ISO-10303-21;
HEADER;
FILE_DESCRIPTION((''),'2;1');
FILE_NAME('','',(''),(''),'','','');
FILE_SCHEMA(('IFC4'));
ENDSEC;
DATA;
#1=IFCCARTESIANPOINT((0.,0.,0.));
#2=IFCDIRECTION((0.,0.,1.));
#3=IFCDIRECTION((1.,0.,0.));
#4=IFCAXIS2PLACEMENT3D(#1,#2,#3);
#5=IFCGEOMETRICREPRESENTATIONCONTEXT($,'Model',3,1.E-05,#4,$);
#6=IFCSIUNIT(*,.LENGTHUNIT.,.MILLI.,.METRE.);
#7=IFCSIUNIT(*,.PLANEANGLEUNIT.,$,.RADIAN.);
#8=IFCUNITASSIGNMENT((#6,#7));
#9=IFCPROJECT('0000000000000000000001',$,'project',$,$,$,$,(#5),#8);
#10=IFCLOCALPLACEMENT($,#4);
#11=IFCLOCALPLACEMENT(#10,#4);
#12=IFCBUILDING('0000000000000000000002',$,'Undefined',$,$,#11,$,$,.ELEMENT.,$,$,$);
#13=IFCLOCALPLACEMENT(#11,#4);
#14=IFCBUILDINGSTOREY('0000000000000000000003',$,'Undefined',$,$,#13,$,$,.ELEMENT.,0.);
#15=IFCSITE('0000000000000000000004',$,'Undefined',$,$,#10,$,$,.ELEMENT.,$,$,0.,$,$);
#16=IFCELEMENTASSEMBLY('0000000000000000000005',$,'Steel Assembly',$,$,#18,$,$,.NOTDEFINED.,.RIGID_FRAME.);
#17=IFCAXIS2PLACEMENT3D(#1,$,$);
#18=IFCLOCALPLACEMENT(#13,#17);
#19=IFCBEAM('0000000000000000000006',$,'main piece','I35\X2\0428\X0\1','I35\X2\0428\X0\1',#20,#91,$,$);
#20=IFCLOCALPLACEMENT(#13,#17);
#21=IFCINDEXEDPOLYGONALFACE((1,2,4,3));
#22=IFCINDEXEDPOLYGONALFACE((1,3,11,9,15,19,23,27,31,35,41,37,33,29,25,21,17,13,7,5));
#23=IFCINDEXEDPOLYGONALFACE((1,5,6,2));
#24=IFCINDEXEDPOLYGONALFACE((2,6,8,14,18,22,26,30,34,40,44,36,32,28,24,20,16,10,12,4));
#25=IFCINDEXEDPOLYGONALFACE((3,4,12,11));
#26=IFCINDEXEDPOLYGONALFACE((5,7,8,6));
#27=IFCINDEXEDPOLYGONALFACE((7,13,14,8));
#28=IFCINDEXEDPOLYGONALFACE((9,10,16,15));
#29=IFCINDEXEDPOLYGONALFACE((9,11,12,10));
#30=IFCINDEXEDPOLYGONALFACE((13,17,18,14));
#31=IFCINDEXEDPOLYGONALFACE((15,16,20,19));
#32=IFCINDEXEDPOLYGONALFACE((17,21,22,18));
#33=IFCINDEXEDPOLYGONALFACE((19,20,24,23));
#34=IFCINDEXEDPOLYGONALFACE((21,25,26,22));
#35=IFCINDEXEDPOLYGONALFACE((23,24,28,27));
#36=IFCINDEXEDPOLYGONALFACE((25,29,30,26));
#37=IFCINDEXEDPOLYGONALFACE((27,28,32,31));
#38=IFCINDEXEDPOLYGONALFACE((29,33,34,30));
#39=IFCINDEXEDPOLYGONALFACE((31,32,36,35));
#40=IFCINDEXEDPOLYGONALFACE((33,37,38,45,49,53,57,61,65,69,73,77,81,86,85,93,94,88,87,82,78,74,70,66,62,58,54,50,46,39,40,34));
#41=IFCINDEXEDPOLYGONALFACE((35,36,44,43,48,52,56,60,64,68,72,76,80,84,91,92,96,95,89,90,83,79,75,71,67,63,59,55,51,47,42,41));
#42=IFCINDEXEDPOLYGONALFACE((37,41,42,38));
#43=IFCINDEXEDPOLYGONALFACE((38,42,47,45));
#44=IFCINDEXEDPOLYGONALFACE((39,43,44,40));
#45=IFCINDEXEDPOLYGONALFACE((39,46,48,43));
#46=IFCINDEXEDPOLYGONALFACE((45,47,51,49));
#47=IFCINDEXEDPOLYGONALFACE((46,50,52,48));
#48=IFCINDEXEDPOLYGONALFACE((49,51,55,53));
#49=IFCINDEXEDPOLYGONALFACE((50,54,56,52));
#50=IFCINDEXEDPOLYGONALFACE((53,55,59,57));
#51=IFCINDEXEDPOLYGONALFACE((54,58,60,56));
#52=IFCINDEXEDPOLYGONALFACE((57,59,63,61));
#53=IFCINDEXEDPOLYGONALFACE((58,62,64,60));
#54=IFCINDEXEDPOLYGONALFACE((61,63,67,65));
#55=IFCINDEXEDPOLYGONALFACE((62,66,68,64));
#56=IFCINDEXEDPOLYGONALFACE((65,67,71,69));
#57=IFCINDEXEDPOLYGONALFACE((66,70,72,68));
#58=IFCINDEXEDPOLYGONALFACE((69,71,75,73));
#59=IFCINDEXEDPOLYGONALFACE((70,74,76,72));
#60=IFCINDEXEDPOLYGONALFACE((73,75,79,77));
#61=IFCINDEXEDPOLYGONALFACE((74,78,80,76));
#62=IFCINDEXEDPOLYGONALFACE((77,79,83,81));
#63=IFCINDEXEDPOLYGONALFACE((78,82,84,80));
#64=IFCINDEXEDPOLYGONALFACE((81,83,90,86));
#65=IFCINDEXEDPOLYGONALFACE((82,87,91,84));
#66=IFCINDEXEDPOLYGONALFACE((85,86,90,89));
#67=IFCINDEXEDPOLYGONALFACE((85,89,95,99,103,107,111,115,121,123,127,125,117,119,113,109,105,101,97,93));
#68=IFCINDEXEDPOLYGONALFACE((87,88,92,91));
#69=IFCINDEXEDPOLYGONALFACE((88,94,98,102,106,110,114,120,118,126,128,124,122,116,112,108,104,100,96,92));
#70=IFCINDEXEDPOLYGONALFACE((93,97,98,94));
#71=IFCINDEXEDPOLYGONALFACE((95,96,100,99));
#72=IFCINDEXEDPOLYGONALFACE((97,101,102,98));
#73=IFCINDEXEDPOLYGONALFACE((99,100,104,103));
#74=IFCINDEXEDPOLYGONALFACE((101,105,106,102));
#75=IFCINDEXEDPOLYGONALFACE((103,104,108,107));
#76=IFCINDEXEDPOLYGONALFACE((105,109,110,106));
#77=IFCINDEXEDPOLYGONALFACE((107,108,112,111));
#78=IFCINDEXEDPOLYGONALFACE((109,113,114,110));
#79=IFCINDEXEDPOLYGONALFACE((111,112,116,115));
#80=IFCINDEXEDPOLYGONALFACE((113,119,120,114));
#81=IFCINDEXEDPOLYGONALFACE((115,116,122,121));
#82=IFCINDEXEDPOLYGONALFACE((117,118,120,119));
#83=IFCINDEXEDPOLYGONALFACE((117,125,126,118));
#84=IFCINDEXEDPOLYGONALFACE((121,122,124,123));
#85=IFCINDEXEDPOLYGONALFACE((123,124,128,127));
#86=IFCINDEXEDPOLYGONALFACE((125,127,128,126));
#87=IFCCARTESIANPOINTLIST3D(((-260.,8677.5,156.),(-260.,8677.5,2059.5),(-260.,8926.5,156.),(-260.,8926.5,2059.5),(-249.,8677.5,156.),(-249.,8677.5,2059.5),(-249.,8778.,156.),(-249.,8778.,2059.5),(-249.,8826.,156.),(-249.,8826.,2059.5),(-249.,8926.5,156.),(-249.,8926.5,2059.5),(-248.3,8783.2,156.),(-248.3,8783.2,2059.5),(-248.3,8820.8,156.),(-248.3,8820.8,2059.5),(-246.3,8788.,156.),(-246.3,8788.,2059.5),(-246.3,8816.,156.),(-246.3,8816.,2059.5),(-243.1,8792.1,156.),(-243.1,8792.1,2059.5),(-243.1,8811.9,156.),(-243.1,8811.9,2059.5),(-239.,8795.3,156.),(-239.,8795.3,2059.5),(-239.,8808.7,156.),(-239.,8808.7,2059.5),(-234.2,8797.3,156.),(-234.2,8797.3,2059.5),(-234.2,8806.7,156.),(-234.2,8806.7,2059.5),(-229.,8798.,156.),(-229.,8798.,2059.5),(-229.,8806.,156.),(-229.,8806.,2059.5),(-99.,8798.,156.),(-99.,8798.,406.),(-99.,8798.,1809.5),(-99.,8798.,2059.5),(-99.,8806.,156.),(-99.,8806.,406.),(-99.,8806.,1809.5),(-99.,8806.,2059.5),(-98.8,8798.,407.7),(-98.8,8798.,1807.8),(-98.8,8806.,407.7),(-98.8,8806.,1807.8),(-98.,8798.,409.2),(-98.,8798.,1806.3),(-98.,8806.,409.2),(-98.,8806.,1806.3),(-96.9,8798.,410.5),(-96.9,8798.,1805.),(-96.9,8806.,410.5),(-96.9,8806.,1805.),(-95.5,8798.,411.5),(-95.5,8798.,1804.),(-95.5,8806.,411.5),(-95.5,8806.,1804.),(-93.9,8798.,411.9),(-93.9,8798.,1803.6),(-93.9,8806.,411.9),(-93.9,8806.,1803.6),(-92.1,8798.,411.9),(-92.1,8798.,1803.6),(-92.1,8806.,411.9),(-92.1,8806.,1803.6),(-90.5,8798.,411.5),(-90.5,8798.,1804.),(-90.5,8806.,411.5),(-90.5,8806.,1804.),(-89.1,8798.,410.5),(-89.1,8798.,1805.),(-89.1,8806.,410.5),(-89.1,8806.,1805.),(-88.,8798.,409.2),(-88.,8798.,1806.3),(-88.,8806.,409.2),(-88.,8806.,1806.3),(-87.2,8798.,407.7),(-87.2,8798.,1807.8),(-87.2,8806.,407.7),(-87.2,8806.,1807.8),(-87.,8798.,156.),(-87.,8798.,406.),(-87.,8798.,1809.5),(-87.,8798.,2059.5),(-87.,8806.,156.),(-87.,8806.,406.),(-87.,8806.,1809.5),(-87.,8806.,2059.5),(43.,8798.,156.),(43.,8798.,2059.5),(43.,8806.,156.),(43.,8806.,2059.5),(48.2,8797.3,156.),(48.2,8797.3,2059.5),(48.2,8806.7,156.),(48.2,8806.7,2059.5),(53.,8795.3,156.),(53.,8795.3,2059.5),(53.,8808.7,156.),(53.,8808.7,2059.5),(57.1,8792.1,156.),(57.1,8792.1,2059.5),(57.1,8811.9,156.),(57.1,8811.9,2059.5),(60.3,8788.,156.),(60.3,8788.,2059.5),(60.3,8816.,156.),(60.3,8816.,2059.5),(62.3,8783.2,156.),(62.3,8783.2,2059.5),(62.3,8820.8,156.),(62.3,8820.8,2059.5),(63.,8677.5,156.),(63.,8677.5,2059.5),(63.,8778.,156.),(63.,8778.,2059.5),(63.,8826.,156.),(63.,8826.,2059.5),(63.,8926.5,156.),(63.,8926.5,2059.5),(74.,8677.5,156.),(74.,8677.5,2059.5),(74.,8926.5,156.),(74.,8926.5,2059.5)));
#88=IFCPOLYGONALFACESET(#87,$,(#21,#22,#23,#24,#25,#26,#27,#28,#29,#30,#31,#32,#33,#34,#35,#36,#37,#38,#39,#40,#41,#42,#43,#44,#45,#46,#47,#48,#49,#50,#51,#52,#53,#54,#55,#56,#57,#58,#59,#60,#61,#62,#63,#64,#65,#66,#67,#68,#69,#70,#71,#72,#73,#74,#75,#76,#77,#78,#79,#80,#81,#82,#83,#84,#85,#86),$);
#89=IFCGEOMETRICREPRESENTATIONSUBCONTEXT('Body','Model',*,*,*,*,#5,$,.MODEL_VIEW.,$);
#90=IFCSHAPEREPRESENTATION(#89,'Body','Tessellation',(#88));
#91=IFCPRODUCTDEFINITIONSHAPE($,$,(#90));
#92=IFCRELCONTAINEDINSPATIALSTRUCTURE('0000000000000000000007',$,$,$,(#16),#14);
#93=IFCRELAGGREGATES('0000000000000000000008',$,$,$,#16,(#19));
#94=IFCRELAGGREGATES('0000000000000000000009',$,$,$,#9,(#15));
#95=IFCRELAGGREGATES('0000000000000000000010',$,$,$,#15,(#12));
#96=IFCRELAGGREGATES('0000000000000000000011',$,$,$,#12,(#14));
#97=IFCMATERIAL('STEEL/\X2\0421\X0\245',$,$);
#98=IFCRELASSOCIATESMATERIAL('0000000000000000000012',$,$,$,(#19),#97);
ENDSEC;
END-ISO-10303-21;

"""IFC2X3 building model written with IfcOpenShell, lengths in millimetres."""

from ifc_helpers import new_model, si_unit, frame, frame_2d, origin_with_axes, origin_2d_with_axis, place, context, subcontext, project, spatial, polyline, circle_curve, parameter, trimmed, segment, composite_curve, i_section, outline, extrude, clip, halfspace, material, element, aggregate, save


model = new_model("IFC2X3")

# Units and contexts
model_context = context("Model", 3, precision=1e-05, world=origin_with_axes())
body_context = subcontext(model_context, "Body", "Model", "MODEL_VIEW")
ifc_project = project(units=[si_unit("LENGTHUNIT", "METRE", prefix="MILLI"), si_unit("PLANEANGLEUNIT", "RADIAN")], contexts=[model_context])

# Site, building, storey
site_placement = place(None, origin_with_axes())
site = spatial("IfcSite", under=ifc_project, at=site_placement, Name="Undefined", CompositionType="ELEMENT", RefElevation=0.0)
building_placement = place(site_placement, origin_with_axes())
building = spatial("IfcBuilding", under=site, at=building_placement, Name="Undefined", CompositionType="ELEMENT")
storey_placement = place(building_placement, origin_with_axes())
storey = spatial("IfcBuildingStorey", under=building, at=storey_placement, Name="Undefined", CompositionType="ELEMENT", Elevation=0.0)

# Element assembly, beam, openings
assembly_1_placement = place(storey_placement, origin_with_axes())
assembly_1 = element("IfcElementAssembly", 1, at=assembly_1_placement, inside=storey, Name="Steel Assembly", AssemblyPlace="NOTDEFINED", PredefinedType="RIGID_FRAME")
ifc_material_1 = material(Name="STEEL/С245")
beam_placement = place(assembly_1_placement, frame((-93.0, 8802.0, 2059.5), z_axis=(-1.0, 0.0, 0.0), x_axis=(0.0, 0.0, -1.0)))
beam = element("IfcBeam", 2, at=beam_placement, material=ifc_material_1, Name="main piece", Description="I35Ш1", ObjectType="I35Ш1", context=body_context, shape_type="Clipping", body=[
    clip(clip(extrude(i_section(OverallWidth=249.0, OverallDepth=334.0, WebThickness=8.0, FlangeThickness=11.0, FilletRadius=20.0, at=origin_2d_with_axis()), frame((1903.5, 0.0, 0.0), z_axis=(-1.0, 0.0, 0.0), x_axis=(0.0, -1.0, 0.0)), (0.0, 0.0, 1.0), 1903.5), halfspace(frame((1903.5, 0.6, 274.0), z_axis=(-1.0, 0.0, 0.0), x_axis=(0.0, -1.0, 0.0)), True)), halfspace(frame((0.0, -0.6, 274.0), z_axis=(1.0, 0.0, 0.0), x_axis=(0.0, 1.0, 0.0)), True)),
])
opening_1_placement = place(assembly_1_placement, frame((-93.0, 8802.0, 2059.5), z_axis=(-1.0, 0.0, 0.0), x_axis=(0.0, 0.0, -1.0)))
element("IfcOpeningElement", 3, at=opening_1_placement, cuts=beam, ObjectType="Recess", context=body_context, shape_type="SweptSolid", body=[
    extrude(outline(composite_curve([segment(polyline([(0.0, 0.0), (250.0, 0.0)]), True, "CONTINUOUS"), segment(trimmed(circle_curve(frame_2d((250.0, 6.0), x_axis=(-0.000939, -1.0)), 6.0), [parameter(0.0)], [parameter(3.14347)], True, "PARAMETER"), True, "CONTINUOUS"), segment(polyline([(250.0, 12.0), (0.0, 12.0), (0.0, 0.0)]), True, "DISCONTINUOUS")], self_intersect=False)), frame((0.0, 102.5, -6.0), z_axis=(0.0, -1.0, 0.0), x_axis=(1.0, 0.0, 0.0)), (0.0, 0.0, 1.0), 205.0),
])
opening_2_placement = place(assembly_1_placement, frame((-93.0, 8802.0, 2059.5), z_axis=(-1.0, 0.0, 0.0), x_axis=(0.0, 0.0, -1.0)))
element("IfcOpeningElement", 4, at=opening_2_placement, cuts=beam, ObjectType="Recess", context=body_context, shape_type="SweptSolid", body=[
    extrude(outline(composite_curve([segment(polyline([(0.0, 0.0), (250.0, 0.0)]), True, "CONTINUOUS"), segment(trimmed(circle_curve(frame_2d((250.0, 6.0), x_axis=(-0.000939, -1.0)), 6.0), [parameter(0.0)], [parameter(3.14347)], True, "PARAMETER"), True, "CONTINUOUS"), segment(polyline([(250.0, 12.0), (0.0, 12.0), (0.0, 0.0)]), True, "DISCONTINUOUS")], self_intersect=False)), frame((1903.5, -102.5, -6.0), z_axis=(0.0, 1.0, 0.0), x_axis=(-1.0, 0.0, 0.0)), (0.0, 0.0, 1.0), 205.0),
])

aggregate(assembly_1, [beam])

save(model, "model.ifc")
